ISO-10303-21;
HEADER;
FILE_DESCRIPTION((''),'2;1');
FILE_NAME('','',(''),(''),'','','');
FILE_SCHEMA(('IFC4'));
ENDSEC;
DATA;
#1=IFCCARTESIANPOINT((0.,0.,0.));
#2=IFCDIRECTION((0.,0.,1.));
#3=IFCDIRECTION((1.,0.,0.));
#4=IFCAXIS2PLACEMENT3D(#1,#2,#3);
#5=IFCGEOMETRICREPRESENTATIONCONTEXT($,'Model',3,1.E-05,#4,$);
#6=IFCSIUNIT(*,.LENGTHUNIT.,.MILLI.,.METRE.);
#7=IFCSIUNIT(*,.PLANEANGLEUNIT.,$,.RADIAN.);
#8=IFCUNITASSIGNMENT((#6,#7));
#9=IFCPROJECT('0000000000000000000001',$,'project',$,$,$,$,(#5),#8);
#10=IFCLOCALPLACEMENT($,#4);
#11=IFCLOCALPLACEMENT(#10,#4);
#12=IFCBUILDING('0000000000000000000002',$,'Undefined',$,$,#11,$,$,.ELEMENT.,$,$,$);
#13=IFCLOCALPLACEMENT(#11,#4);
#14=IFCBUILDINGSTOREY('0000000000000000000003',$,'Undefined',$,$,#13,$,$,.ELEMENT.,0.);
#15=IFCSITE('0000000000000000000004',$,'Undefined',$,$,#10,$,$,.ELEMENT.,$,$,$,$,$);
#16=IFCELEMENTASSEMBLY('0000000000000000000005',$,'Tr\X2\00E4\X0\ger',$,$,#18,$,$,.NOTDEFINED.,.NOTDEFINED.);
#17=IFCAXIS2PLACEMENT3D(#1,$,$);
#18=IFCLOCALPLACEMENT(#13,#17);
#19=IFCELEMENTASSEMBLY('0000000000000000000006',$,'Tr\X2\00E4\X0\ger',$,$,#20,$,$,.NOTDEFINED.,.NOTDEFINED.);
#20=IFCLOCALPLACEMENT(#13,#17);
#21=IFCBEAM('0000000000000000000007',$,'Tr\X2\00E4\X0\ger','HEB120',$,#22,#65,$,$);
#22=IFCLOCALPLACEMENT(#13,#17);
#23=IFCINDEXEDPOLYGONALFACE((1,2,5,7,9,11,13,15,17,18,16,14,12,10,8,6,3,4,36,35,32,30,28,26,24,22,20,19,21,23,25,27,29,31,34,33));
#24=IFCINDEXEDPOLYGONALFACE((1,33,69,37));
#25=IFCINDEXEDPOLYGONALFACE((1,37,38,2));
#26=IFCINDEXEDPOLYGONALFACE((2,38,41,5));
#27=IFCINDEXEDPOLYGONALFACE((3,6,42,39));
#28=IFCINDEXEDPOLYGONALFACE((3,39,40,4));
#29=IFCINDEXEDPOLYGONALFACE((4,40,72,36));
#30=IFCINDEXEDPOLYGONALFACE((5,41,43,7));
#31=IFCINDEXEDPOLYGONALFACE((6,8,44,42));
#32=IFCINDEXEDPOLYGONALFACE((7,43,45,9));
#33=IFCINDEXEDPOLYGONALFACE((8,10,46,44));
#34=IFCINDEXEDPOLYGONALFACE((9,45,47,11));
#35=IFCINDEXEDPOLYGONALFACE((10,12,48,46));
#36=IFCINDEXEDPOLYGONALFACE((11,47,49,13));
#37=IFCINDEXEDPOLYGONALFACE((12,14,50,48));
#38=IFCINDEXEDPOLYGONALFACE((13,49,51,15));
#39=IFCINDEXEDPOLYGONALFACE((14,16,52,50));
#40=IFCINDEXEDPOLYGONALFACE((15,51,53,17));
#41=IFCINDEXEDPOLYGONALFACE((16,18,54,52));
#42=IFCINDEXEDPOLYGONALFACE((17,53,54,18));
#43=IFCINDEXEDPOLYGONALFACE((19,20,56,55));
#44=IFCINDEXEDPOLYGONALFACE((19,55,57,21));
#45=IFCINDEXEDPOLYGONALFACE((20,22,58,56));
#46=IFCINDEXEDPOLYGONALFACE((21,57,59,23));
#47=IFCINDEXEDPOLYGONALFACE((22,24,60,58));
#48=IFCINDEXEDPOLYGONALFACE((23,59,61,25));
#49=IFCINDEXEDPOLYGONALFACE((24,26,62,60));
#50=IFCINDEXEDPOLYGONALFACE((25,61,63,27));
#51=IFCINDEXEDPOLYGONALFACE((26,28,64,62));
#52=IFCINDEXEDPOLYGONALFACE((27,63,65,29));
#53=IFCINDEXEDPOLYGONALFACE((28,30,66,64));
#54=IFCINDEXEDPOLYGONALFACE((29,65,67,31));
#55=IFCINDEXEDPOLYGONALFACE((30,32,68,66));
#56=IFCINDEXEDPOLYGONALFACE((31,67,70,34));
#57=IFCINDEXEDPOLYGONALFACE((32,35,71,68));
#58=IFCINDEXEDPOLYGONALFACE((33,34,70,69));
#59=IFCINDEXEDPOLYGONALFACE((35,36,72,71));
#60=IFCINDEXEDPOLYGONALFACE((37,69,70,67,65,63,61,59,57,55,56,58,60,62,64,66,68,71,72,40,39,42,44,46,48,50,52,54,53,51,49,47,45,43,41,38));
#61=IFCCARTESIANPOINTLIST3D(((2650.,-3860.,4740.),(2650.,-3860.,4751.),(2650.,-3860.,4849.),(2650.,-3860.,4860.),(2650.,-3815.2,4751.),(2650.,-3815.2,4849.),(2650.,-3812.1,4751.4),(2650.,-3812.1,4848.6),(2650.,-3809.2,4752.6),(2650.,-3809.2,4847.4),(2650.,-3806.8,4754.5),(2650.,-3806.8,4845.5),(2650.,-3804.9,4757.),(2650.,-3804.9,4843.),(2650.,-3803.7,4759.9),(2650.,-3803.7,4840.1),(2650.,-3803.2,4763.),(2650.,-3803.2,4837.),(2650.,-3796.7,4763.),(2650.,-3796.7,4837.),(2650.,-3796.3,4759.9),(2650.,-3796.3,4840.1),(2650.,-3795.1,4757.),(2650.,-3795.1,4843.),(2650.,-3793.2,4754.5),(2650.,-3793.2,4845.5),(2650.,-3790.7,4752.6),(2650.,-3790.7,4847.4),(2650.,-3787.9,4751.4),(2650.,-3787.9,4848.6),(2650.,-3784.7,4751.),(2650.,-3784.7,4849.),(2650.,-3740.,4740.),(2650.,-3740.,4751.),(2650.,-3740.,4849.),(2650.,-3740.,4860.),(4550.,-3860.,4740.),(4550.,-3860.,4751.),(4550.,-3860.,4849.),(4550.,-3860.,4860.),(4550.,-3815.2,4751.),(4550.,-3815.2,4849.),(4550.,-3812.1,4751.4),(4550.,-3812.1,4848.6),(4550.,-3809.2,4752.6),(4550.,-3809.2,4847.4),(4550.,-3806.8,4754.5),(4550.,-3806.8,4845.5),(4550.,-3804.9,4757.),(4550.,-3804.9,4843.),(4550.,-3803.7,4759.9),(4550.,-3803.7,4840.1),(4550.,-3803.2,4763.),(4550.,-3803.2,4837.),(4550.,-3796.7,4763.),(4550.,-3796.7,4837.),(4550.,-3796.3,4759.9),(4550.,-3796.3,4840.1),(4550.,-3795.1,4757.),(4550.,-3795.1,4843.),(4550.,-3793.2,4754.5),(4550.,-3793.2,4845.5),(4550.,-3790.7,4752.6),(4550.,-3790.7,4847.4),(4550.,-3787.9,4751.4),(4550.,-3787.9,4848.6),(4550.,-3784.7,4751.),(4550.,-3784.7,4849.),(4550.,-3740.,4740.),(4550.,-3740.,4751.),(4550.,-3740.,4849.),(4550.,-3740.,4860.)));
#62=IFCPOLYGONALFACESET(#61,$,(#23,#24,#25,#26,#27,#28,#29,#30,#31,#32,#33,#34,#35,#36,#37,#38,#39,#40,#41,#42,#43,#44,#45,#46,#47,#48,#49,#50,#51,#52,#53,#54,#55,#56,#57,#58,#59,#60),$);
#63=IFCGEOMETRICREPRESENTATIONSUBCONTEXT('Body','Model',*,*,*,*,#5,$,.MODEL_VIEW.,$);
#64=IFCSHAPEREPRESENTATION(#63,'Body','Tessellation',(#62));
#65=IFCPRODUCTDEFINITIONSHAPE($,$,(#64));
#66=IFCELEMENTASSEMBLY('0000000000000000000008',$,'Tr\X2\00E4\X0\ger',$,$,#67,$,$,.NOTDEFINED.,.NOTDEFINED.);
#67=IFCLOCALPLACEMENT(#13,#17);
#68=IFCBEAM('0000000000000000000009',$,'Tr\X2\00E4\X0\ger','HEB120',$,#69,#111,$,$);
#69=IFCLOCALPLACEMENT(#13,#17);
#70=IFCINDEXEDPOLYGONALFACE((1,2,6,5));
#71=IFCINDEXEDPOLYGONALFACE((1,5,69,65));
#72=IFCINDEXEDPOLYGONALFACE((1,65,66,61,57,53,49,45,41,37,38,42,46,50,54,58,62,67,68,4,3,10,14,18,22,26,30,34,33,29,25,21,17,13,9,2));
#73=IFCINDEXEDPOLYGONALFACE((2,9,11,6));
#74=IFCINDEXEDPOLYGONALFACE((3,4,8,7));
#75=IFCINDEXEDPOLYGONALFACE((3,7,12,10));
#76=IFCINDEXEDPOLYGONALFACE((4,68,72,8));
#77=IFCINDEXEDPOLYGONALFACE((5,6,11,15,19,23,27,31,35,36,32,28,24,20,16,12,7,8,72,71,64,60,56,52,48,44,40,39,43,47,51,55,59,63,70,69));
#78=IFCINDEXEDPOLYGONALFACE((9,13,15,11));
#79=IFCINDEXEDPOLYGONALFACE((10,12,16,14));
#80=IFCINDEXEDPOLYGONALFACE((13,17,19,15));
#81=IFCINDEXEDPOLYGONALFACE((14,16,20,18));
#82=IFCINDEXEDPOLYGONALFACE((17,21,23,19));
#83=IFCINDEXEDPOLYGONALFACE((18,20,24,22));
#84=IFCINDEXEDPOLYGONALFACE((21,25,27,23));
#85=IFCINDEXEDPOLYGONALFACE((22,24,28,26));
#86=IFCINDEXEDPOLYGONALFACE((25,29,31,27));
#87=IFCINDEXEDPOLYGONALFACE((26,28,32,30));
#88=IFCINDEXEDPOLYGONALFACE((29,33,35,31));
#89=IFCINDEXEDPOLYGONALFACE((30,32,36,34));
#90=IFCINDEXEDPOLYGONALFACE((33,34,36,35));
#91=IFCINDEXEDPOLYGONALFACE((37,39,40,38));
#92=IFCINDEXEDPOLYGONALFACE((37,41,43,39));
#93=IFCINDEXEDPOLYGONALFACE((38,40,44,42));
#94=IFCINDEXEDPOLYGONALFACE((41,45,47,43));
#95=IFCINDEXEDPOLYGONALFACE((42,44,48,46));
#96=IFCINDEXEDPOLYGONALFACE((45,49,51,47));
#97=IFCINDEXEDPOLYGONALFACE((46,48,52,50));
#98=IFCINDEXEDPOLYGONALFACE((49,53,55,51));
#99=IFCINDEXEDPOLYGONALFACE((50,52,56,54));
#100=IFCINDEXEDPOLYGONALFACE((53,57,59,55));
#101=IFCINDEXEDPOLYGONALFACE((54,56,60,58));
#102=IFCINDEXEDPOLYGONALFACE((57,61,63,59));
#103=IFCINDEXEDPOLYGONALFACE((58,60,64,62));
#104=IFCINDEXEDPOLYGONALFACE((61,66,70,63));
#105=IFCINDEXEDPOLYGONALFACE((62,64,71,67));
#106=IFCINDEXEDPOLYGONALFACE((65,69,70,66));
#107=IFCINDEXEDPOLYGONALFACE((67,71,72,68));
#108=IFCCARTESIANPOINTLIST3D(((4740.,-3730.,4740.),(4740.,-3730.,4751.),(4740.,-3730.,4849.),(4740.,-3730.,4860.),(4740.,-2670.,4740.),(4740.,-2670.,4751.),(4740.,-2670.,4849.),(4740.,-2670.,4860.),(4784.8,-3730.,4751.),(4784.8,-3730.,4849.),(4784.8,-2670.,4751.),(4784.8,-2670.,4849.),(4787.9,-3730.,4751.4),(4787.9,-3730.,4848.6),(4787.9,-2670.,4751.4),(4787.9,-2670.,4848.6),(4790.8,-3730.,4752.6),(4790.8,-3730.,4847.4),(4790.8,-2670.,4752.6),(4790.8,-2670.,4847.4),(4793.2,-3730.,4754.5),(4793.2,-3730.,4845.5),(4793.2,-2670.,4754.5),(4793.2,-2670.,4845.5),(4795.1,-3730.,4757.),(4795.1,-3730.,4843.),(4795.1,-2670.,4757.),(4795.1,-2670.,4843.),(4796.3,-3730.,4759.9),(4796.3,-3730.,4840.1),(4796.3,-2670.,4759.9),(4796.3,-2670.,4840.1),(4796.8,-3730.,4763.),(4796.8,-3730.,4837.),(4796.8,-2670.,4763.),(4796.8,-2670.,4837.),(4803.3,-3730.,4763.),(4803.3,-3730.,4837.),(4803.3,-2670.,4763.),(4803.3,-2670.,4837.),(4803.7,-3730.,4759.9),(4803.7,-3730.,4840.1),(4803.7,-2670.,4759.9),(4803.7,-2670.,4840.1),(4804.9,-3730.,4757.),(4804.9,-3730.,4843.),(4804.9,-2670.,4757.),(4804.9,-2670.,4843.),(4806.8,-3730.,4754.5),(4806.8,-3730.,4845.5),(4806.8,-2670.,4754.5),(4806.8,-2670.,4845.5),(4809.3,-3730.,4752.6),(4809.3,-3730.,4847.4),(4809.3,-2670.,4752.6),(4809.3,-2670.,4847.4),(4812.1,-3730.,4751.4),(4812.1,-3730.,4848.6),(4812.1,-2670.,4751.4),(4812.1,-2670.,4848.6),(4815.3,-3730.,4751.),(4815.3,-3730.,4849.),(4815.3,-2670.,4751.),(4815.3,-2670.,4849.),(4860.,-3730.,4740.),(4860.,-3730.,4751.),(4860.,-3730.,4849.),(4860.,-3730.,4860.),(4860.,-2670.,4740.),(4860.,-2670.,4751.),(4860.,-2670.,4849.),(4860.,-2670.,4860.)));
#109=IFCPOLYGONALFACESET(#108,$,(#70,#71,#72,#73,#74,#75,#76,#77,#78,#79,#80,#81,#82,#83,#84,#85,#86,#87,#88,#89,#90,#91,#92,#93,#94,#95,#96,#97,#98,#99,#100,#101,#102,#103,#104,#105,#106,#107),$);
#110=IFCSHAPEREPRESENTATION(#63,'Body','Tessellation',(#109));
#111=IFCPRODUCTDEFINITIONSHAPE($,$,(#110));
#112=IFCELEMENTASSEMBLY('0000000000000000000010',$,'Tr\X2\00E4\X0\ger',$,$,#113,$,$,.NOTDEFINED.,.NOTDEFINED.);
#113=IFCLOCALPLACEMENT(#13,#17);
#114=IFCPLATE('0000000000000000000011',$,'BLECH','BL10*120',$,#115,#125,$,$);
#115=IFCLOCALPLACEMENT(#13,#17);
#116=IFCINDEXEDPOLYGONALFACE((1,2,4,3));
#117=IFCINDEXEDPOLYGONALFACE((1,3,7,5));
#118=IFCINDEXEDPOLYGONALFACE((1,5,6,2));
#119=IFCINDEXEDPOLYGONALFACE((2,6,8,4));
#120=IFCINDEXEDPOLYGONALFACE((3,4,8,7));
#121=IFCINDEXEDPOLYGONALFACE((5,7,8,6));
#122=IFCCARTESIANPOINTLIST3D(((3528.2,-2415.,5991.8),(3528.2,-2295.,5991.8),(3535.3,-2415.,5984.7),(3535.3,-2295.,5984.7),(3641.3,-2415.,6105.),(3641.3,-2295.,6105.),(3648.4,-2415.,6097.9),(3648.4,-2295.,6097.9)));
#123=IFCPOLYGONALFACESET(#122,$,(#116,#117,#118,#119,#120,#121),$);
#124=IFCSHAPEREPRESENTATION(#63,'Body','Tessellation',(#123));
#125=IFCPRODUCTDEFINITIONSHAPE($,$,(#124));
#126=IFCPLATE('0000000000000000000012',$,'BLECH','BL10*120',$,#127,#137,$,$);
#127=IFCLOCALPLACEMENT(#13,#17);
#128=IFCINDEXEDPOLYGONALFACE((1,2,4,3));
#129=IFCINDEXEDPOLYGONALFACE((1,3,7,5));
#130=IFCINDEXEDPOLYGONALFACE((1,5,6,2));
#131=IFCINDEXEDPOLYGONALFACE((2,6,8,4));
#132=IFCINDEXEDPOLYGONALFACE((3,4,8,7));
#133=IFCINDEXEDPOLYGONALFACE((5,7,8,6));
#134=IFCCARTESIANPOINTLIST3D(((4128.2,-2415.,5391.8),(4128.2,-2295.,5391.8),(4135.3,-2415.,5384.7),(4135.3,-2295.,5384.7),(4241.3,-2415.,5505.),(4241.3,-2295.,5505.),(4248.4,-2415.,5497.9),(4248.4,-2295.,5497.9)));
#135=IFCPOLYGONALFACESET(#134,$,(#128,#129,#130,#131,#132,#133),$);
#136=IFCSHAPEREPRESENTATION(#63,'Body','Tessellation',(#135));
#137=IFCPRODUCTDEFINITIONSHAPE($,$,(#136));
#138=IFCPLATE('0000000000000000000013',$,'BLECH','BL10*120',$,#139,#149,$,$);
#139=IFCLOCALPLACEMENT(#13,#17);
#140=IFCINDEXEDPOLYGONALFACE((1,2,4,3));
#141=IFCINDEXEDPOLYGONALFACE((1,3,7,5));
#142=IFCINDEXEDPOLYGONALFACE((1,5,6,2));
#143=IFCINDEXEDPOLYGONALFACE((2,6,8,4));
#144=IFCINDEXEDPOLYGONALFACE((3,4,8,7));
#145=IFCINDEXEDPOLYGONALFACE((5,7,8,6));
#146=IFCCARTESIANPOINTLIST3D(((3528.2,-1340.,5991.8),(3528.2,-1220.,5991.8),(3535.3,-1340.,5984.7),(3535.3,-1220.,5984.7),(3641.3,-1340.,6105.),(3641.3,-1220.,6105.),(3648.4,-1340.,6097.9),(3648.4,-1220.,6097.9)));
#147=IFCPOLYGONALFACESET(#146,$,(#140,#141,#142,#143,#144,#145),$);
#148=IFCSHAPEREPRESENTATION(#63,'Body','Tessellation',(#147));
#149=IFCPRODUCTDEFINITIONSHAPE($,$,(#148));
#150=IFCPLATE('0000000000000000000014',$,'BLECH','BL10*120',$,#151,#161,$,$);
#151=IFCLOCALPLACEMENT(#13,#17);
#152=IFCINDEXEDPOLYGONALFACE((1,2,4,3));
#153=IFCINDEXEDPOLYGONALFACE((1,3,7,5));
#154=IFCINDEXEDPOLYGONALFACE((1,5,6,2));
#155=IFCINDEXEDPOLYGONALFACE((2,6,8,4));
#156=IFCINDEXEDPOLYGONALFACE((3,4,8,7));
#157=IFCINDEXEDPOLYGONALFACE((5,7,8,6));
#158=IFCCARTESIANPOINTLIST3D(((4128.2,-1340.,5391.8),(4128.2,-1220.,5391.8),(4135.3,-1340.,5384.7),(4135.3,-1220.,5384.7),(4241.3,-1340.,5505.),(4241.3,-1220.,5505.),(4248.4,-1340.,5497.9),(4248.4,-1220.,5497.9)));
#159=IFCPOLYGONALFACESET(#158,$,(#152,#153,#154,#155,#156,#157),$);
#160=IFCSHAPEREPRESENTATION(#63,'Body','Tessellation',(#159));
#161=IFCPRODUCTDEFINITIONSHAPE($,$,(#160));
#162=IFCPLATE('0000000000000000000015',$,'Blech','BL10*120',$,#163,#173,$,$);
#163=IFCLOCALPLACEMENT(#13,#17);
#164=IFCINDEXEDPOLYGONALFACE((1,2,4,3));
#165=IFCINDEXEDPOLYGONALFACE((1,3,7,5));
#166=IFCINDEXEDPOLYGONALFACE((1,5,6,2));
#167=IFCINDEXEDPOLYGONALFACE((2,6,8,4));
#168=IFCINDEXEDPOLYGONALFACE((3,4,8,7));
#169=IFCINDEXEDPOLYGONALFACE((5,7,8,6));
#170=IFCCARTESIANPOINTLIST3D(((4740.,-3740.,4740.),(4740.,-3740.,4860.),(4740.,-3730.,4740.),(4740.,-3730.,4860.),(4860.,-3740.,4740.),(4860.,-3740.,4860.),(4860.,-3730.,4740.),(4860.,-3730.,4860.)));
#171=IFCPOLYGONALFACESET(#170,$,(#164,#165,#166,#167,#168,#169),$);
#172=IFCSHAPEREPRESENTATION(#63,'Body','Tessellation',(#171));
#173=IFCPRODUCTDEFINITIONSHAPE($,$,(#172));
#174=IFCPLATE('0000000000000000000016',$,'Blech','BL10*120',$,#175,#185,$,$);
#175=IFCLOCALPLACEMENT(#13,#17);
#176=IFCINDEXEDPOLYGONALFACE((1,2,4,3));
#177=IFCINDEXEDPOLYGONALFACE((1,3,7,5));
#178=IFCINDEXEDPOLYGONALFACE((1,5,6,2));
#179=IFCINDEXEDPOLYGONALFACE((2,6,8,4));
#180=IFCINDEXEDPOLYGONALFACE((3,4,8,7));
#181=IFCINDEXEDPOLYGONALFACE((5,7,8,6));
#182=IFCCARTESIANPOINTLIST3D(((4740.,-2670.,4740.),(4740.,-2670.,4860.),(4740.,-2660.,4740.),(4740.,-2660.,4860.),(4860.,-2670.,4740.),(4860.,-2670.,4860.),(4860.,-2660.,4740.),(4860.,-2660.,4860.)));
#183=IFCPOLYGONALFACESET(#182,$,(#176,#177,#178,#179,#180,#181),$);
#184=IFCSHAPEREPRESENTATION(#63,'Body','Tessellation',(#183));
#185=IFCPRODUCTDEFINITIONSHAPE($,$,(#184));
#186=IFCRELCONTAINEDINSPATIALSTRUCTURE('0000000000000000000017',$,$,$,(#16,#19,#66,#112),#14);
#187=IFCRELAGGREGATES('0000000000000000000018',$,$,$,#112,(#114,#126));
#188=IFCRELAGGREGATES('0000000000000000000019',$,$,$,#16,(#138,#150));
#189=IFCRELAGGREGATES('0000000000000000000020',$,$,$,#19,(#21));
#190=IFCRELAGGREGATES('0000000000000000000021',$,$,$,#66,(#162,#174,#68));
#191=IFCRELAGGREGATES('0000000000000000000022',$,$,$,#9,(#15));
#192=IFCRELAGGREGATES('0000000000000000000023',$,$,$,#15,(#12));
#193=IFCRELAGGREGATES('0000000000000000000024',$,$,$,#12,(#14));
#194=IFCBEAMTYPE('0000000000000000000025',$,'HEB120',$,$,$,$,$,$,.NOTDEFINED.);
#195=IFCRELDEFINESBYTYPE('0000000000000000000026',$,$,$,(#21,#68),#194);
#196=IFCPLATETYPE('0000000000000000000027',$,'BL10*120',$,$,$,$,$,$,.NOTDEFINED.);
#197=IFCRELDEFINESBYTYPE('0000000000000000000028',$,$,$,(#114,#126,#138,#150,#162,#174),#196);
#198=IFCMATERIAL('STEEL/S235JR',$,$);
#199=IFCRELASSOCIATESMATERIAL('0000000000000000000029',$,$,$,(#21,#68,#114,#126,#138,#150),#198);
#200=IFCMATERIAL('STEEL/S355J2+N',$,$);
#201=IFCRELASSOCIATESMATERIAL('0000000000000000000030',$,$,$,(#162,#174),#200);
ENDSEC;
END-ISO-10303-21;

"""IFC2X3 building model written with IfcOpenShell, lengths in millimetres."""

from ifc_helpers import new_model, si_unit, frame, origin_with_axes, origin_2d_with_axis, place, context, subcontext, project, spatial, polyline, i_section, outline, extrude, clip, halfspace, material, type_object, element, aggregate, save


model = new_model("IFC2X3")

# Units and contexts
model_context = context("Model", 3, precision=1e-05, world=origin_with_axes())
body_context = subcontext(model_context, "Body", "Model", "MODEL_VIEW")
ifc_project = project(units=[si_unit("LENGTHUNIT", "METRE", prefix="MILLI"), si_unit("PLANEANGLEUNIT", "RADIAN")], contexts=[model_context])

# Site, building, storey
site_placement = place(None, origin_with_axes())
site = spatial("IfcSite", under=ifc_project, at=site_placement, Name="Undefined", CompositionType="ELEMENT")
building_placement = place(site_placement, origin_with_axes())
building = spatial("IfcBuilding", under=site, at=building_placement, Name="Undefined", CompositionType="ELEMENT")
storey_placement = place(building_placement, origin_with_axes())
storey = spatial("IfcBuildingStorey", under=building, at=storey_placement, Name="Undefined", CompositionType="ELEMENT", Elevation=0.0)

# Element assemblies, beams
ifc_material_1 = material(Name="STEEL/S235JR")
assembly_1_placement = place(storey_placement, origin_with_axes())
assembly_1 = element("IfcElementAssembly", 1, at=assembly_1_placement, inside=storey, Name="Träger", AssemblyPlace="NOTDEFINED", PredefinedType="NOTDEFINED")
beam_type_1 = type_object("IfcBeamType", Name="HEB120", PredefinedType="NOTDEFINED")
assembly_2_placement = place(storey_placement, origin_with_axes())
assembly_2 = element("IfcElementAssembly", 2, at=assembly_2_placement, inside=storey, Name="Träger", AssemblyPlace="NOTDEFINED", PredefinedType="NOTDEFINED")
beam_1_placement = place(assembly_2_placement, frame((4550.0, -3800.0, 4800.0), z_axis=(0.0, 0.0, 1.0), x_axis=(-1.0, 0.0, 0.0)))
beam_1 = element("IfcBeam", 3, at=beam_1_placement, type_object=beam_type_1, material=ifc_material_1, Name="Träger", Description="HEB120", context=body_context, shape_type="Clipping", body=[
    clip(clip(extrude(i_section(OverallWidth=120.0, OverallDepth=120.0, WebThickness=6.5, FlangeThickness=11.0, FilletRadius=12.0, at=origin_2d_with_axis()), frame((1910.0, 0.0, 0.0), z_axis=(-1.0, 0.0, 0.0), x_axis=(0.0, -1.0, 0.0)), (0.0, 0.0, 1.0), 1910.0), halfspace(frame((1900.0, 0.0, -60.0), z_axis=(-1.0, 0.0, 0.0), x_axis=(0.0, 1.0, 0.0)), True)), halfspace(frame((0.0, 0.0, -60.0), z_axis=(1.0, 0.0, 0.0), x_axis=(0.0, -1.0, 0.0)), True)),
])
assembly_3_placement = place(storey_placement, origin_with_axes())
assembly_3 = element("IfcElementAssembly", 4, at=assembly_3_placement, inside=storey, Name="Träger", AssemblyPlace="NOTDEFINED", PredefinedType="NOTDEFINED")
beam_2_placement = place(assembly_3_placement, frame((4800.0, -2670.0, 4800.0), z_axis=(0.0, 0.0, 1.0), x_axis=(0.0, -1.0, 0.0)))
beam_2 = element("IfcBeam", 5, at=beam_2_placement, type_object=beam_type_1, material=ifc_material_1, Name="Träger", Description="HEB120", context=body_context, shape_type="Clipping", body=[
    clip(clip(extrude(i_section(OverallWidth=120.0, OverallDepth=120.0, WebThickness=6.5, FlangeThickness=11.0, FilletRadius=12.0, at=origin_2d_with_axis()), frame((1060.0, 0.0, 0.0), z_axis=(-1.0, 0.0, 0.0), x_axis=(0.0, -1.0, 0.0)), (0.0, 0.0, 1.0), 1060.0), halfspace(frame((1060.0, 0.0, -60.0), z_axis=(-1.0, 0.0, 0.0), x_axis=(0.0, 1.0, 0.0)), True)), halfspace(frame((0.0, 0.0, -60.0), z_axis=(1.0, 0.0, 0.0), x_axis=(0.0, -1.0, 0.0)), True)),
])

# Element assembly, plates
assembly_4_placement = place(storey_placement, origin_with_axes())
assembly_4 = element("IfcElementAssembly", 6, at=assembly_4_placement, inside=storey, Name="Träger", AssemblyPlace="NOTDEFINED", PredefinedType="NOTDEFINED")
plate_type = type_object("IfcPlateType", Name="BL10*120", PredefinedType="NOTDEFINED")
plate_1_placement = place(assembly_4_placement, frame((3531.7, -2295.0, 5988.3), z_axis=(-0.707107, 0.0, 0.707107), x_axis=(0.0, -1.0, 0.0)))
plate_1 = element("IfcPlate", 7, at=plate_1_placement, type_object=plate_type, material=ifc_material_1, Name="BLECH", Description="BL10*120", context=body_context, shape_type="SweptSolid", body=[
    extrude(outline(polyline([(0.0, 0.0), (120.0, 0.0), (120.0, 160.0), (0.0, 160.0), (0.0, 0.0)])), frame((0.0, 0.0, -5.0), z_axis=(0.0, 0.0, 1.0), x_axis=(1.0, 0.0, 0.0)), (0.0, 0.0, 1.0), 10.0),
])
plate_2_placement = place(assembly_4_placement, frame((4131.7, -2295.0, 5388.3), z_axis=(-0.707107, 0.0, 0.707107), x_axis=(0.0, -1.0, 0.0)))
plate_2 = element("IfcPlate", 8, at=plate_2_placement, type_object=plate_type, material=ifc_material_1, Name="BLECH", Description="BL10*120", context=body_context, shape_type="SweptSolid", body=[
    extrude(outline(polyline([(0.0, 0.0), (120.0, 0.0), (120.0, 160.0), (0.0, 160.0), (0.0, 0.0)])), frame((0.0, 0.0, -5.0), z_axis=(0.0, 0.0, 1.0), x_axis=(1.0, 0.0, 0.0)), (0.0, 0.0, 1.0), 10.0),
])

# Plates
plate_3_placement = place(assembly_1_placement, frame((3531.7, -1340.0, 5988.3), z_axis=(0.707107, 0.0, -0.707107), x_axis=(0.0, 1.0, 0.0)))
plate_3 = element("IfcPlate", 9, at=plate_3_placement, type_object=plate_type, material=ifc_material_1, Name="BLECH", Description="BL10*120", context=body_context, shape_type="SweptSolid", body=[
    extrude(outline(polyline([(0.0, 0.0), (120.0, 0.0), (120.0, 160.0), (0.0, 160.0), (0.0, 0.0)])), frame((0.0, 0.0, -5.0), z_axis=(0.0, 0.0, 1.0), x_axis=(1.0, 0.0, 0.0)), (0.0, 0.0, 1.0), 10.0),
])
plate_4_placement = place(assembly_1_placement, frame((4131.7, -1340.0, 5388.3), z_axis=(0.707107, 0.0, -0.707107), x_axis=(0.0, 1.0, 0.0)))
plate_4 = element("IfcPlate", 10, at=plate_4_placement, type_object=plate_type, material=ifc_material_1, Name="BLECH", Description="BL10*120", context=body_context, shape_type="SweptSolid", body=[
    extrude(outline(polyline([(0.0, 0.0), (120.0, 0.0), (120.0, 160.0), (0.0, 160.0), (0.0, 0.0)])), frame((0.0, 0.0, -5.0), z_axis=(0.0, 0.0, 1.0), x_axis=(1.0, 0.0, 0.0)), (0.0, 0.0, 1.0), 10.0),
])
ifc_material_2 = material(Name="STEEL/S355J2+N")
plate_5_placement = place(assembly_3_placement, frame((4800.0, -3735.0, 4740.0), z_axis=(0.0, 1.0, 0.0), x_axis=(0.0, 0.0, 1.0)))
plate_5 = element("IfcPlate", 11, at=plate_5_placement, type_object=plate_type, material=ifc_material_2, Name="Blech", Description="BL10*120", context=body_context, shape_type="SweptSolid", body=[
    extrude(outline(polyline([(0.0, -60.0), (0.0, 60.0), (120.0, 60.0), (120.0, -60.0), (0.0, -60.0)])), frame((0.0, 0.0, -5.0), z_axis=(0.0, 0.0, 1.0), x_axis=(1.0, 0.0, 0.0)), (0.0, 0.0, 1.0), 10.0),
])
plate_6_placement = place(assembly_3_placement, frame((4800.0, -2665.0, 4740.0), z_axis=(0.0, -1.0, 0.0), x_axis=(0.0, 0.0, 1.0)))
plate_6 = element("IfcPlate", 12, at=plate_6_placement, type_object=plate_type, material=ifc_material_2, Name="Blech", Description="BL10*120", context=body_context, shape_type="SweptSolid", body=[
    extrude(outline(polyline([(0.0, -60.0), (0.0, 60.0), (120.0, 60.0), (120.0, -60.0), (0.0, -60.0)])), frame((0.0, 0.0, -5.0), z_axis=(0.0, 0.0, 1.0), x_axis=(1.0, 0.0, 0.0)), (0.0, 0.0, 1.0), 10.0),
])

aggregate(assembly_4, [plate_1, plate_2])
aggregate(assembly_1, [plate_3, plate_4])
aggregate(assembly_2, [beam_1])
aggregate(assembly_3, [plate_5, plate_6, beam_2])

save(model, "model.ifc")
